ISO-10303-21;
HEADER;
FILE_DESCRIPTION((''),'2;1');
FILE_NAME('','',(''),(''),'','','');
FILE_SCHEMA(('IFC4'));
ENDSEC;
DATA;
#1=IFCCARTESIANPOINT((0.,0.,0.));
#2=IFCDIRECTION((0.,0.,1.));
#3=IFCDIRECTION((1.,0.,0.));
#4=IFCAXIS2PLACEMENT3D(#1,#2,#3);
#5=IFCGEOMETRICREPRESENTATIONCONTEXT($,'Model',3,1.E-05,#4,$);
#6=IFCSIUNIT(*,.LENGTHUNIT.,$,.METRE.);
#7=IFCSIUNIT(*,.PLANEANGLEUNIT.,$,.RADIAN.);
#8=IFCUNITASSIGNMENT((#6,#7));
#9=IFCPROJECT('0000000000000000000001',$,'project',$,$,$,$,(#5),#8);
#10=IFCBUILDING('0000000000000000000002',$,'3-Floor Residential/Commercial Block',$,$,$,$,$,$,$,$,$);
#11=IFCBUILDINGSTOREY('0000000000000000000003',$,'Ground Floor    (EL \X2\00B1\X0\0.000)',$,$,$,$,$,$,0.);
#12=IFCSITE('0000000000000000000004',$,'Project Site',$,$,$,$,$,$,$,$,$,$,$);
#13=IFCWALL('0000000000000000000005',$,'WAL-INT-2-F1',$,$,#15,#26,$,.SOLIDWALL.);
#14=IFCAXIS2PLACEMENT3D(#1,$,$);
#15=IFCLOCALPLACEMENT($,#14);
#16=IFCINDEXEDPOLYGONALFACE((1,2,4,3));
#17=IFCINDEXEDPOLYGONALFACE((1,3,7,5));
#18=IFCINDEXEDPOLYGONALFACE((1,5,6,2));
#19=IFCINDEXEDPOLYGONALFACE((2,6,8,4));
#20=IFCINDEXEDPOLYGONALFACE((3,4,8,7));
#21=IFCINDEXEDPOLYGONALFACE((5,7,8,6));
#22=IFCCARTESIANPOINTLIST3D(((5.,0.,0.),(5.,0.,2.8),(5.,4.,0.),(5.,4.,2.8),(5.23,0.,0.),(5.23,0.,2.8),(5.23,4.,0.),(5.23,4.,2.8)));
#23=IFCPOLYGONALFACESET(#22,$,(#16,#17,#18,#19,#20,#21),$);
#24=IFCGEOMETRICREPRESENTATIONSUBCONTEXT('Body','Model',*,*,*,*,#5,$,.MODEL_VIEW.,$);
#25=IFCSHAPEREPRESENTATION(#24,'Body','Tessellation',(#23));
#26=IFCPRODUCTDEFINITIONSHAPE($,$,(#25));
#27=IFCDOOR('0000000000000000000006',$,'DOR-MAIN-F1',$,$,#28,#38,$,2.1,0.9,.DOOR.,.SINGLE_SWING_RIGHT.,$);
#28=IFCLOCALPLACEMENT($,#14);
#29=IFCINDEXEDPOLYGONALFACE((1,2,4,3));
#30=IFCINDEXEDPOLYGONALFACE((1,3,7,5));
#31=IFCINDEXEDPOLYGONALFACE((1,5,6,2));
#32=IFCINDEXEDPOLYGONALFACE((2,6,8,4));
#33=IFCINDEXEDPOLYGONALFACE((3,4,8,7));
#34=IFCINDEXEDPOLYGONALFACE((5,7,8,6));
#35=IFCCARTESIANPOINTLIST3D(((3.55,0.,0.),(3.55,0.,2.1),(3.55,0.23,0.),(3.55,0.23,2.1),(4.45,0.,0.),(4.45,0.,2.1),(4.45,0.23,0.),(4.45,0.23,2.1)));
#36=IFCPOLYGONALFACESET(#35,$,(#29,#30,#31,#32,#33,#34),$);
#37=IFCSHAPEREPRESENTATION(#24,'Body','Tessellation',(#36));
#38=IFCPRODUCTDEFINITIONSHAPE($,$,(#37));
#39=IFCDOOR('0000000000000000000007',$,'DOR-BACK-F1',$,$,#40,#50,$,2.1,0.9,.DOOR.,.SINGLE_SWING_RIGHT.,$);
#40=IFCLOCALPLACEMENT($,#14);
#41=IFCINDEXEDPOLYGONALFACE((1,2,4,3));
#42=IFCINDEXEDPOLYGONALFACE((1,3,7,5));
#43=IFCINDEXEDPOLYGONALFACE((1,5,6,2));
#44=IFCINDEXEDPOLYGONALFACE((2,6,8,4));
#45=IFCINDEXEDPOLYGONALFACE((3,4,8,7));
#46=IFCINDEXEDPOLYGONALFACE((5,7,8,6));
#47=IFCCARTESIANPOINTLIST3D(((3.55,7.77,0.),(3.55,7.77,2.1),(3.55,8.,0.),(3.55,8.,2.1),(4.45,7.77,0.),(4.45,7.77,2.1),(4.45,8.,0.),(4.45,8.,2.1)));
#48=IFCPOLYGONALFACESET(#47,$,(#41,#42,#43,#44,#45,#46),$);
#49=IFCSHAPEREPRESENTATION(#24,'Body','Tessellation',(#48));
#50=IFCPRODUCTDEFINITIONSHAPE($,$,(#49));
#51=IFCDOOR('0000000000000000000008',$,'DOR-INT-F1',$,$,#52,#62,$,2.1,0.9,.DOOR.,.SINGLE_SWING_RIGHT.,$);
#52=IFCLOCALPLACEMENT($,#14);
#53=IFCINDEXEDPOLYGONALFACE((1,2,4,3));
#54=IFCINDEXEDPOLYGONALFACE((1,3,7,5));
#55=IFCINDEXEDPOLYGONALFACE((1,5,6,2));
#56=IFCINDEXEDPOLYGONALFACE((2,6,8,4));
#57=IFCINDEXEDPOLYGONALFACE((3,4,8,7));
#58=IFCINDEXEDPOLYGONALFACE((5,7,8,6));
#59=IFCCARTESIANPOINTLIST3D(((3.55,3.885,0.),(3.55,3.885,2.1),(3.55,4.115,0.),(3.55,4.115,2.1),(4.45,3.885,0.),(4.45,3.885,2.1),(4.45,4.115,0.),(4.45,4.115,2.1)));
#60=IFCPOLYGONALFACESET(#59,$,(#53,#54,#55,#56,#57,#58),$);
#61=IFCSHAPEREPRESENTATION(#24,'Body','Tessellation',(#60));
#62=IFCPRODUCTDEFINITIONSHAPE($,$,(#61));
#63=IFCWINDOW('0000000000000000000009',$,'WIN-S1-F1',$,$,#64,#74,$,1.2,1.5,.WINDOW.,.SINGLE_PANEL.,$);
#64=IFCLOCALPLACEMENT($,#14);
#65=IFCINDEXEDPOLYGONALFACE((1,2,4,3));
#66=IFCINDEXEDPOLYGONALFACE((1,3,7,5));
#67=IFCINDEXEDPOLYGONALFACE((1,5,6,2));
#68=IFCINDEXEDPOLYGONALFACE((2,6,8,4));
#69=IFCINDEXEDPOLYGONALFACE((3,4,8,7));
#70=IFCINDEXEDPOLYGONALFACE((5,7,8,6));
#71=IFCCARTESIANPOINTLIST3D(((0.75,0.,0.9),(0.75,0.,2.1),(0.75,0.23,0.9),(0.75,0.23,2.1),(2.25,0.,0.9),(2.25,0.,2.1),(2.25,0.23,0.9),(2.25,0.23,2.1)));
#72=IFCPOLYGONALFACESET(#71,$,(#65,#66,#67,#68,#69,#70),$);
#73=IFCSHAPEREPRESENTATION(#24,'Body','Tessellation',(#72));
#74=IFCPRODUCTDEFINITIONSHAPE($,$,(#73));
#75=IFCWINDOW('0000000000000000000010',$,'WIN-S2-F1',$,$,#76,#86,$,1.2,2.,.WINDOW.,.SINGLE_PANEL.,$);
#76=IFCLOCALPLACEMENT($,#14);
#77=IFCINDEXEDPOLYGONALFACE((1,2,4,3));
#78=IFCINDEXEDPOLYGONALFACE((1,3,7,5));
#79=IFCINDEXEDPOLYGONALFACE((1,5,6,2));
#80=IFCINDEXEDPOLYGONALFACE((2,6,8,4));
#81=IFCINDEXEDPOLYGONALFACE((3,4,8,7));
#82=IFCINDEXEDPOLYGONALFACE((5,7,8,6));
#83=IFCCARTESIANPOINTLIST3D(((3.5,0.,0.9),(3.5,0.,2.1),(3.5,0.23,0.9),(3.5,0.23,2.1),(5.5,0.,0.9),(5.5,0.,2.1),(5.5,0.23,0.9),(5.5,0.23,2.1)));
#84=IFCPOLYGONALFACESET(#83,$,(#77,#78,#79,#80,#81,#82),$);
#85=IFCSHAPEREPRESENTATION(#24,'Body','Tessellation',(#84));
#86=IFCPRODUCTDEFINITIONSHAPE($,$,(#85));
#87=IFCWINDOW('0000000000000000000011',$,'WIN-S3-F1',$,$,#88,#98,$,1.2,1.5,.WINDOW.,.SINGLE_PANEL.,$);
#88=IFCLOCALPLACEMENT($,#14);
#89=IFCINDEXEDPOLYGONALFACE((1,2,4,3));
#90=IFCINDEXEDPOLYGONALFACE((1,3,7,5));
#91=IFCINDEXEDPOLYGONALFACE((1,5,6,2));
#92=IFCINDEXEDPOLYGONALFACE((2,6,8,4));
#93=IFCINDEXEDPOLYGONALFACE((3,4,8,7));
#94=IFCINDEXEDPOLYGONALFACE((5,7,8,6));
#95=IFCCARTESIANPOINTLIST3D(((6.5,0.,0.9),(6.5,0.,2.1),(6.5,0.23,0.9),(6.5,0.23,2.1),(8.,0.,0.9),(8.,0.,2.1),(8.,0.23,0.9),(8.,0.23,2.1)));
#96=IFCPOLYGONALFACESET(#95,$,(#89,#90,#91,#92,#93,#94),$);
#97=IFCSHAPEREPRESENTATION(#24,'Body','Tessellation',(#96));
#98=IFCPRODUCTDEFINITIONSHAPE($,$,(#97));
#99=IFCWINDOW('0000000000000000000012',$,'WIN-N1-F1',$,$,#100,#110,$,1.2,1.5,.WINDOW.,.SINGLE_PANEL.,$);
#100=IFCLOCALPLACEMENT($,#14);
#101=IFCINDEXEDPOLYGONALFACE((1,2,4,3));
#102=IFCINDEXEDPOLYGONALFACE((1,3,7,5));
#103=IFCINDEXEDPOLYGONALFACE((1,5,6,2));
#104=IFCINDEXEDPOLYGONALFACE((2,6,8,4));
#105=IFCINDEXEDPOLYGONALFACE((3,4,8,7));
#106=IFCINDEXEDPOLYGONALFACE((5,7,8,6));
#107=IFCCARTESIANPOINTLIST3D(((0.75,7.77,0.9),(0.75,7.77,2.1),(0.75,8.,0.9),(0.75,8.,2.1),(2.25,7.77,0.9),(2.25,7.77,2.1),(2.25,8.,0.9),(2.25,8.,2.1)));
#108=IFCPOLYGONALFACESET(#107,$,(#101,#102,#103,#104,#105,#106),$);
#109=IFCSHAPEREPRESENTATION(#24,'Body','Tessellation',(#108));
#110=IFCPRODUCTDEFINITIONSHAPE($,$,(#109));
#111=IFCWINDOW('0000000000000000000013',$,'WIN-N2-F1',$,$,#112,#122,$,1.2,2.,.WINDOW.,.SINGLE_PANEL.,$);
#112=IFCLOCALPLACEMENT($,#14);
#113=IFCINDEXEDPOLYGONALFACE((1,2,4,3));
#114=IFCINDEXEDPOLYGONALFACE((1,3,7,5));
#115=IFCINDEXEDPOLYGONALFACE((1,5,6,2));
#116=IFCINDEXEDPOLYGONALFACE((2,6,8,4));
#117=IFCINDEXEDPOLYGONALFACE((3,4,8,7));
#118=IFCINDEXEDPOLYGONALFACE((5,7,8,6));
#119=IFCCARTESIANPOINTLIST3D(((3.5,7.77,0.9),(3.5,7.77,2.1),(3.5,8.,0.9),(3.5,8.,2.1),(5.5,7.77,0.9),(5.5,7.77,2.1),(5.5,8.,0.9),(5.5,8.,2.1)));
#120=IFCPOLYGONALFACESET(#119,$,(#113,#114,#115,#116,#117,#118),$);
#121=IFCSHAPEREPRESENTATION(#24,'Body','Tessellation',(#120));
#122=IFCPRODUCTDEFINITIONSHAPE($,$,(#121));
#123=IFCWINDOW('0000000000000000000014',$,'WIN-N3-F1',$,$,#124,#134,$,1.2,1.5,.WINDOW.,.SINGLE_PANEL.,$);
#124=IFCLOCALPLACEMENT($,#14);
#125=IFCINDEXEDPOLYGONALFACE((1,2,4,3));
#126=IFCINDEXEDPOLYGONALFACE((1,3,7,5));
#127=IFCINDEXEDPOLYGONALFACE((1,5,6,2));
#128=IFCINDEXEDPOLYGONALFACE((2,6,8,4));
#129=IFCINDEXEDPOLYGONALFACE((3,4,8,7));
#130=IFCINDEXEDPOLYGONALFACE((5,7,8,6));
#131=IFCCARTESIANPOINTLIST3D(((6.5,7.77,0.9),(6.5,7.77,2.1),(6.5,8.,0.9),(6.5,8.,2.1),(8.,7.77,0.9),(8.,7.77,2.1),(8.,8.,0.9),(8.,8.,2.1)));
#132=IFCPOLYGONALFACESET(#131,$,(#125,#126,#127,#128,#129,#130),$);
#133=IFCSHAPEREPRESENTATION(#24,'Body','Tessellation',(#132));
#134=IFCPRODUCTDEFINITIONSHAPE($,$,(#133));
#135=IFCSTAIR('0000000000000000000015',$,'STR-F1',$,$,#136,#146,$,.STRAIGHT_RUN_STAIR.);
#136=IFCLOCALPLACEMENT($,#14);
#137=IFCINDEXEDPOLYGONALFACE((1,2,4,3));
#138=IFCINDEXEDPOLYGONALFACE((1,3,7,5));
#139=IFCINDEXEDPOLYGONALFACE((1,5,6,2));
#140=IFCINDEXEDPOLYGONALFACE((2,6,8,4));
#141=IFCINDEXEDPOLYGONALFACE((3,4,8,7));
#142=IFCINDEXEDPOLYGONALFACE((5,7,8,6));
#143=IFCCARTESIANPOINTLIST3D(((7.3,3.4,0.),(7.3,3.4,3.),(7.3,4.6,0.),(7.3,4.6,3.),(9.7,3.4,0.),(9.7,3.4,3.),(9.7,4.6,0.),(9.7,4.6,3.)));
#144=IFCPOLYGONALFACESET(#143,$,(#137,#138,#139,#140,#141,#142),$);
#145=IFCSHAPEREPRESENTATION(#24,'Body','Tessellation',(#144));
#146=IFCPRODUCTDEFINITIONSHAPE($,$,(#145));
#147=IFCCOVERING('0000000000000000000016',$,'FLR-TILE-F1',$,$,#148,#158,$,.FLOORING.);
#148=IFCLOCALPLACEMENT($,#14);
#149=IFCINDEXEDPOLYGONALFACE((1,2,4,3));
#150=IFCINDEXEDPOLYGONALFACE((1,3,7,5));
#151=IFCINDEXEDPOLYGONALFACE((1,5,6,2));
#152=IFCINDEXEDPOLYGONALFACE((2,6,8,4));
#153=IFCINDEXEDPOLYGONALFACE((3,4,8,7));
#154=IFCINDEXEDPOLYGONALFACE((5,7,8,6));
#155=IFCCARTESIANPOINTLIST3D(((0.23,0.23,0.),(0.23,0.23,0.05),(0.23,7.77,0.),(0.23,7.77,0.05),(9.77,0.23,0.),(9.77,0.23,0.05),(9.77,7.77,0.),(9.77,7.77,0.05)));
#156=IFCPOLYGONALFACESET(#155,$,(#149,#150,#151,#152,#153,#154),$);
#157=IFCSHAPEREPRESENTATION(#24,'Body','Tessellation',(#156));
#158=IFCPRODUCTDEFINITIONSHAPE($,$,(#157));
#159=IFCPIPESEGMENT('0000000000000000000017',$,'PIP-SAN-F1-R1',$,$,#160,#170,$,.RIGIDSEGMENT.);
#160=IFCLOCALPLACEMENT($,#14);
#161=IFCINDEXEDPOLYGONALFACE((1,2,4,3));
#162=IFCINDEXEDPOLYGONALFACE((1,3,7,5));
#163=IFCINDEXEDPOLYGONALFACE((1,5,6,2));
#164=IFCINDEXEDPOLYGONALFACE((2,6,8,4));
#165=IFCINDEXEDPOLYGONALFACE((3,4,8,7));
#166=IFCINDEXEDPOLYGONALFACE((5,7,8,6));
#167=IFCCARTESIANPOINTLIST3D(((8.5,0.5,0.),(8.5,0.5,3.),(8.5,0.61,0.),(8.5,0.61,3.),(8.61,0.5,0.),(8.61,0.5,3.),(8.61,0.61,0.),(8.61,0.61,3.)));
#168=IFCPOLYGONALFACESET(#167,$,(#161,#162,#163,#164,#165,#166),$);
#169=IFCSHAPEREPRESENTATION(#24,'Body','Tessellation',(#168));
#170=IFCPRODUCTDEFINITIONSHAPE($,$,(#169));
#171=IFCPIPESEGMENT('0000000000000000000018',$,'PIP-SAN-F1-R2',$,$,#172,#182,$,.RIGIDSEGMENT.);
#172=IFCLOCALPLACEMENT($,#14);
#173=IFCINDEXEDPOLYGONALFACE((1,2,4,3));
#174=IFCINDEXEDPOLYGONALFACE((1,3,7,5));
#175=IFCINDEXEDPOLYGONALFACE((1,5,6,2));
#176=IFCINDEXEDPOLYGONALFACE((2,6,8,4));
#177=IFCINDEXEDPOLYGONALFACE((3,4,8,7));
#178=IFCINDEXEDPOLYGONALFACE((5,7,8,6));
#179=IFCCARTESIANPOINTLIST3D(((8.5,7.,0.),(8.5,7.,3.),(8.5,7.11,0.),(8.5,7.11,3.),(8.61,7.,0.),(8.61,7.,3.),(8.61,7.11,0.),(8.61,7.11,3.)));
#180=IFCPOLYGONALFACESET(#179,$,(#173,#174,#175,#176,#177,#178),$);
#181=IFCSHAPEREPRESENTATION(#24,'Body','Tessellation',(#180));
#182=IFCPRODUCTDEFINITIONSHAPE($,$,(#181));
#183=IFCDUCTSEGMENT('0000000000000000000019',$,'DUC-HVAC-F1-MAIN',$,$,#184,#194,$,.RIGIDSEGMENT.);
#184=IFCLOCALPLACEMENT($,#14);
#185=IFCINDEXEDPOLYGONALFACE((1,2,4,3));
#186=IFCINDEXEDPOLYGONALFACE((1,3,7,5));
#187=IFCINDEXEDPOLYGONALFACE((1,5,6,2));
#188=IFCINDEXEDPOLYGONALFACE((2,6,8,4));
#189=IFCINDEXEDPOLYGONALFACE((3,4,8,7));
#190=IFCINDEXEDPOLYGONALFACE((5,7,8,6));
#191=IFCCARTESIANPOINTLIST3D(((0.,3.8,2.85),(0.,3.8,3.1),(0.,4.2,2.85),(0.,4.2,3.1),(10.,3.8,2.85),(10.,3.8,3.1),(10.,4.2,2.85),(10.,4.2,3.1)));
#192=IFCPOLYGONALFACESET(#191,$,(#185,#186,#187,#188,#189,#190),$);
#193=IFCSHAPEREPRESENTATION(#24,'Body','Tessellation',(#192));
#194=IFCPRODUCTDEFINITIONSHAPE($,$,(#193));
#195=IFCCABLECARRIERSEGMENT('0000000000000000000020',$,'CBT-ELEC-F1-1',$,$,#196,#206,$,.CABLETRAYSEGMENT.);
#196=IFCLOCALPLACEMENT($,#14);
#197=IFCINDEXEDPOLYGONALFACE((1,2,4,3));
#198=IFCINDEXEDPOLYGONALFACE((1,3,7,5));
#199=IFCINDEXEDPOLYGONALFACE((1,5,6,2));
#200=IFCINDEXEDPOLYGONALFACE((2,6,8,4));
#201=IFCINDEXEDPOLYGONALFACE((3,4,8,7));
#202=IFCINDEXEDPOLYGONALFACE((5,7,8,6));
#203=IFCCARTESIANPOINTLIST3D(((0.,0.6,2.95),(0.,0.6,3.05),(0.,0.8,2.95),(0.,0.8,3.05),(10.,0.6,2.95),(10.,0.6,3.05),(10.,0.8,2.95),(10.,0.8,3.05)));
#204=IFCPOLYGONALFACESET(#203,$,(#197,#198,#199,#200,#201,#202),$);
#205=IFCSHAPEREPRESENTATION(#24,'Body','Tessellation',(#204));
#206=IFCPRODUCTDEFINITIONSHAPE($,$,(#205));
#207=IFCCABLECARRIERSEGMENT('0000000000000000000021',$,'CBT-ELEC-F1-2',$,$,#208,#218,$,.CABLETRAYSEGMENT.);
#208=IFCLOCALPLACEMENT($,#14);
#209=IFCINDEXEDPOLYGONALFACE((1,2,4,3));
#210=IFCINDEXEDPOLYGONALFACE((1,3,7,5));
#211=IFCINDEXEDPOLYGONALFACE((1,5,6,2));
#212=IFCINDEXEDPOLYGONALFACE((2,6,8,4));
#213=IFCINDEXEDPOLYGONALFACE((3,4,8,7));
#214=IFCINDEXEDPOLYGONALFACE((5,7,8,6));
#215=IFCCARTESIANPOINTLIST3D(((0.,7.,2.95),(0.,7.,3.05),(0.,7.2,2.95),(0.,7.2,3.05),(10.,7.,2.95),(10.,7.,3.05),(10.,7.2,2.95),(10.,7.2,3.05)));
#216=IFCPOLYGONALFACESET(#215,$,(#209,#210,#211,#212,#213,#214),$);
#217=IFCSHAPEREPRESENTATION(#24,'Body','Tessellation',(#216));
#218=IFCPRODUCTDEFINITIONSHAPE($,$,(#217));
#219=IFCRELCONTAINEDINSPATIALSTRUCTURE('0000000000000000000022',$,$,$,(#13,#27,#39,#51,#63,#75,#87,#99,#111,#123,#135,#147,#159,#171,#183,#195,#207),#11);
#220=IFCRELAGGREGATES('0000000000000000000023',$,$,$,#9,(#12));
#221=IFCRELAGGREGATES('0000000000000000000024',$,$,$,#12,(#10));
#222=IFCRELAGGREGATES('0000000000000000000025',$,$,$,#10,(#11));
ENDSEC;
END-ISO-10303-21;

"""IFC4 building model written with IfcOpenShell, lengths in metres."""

from ifc_helpers import new_model, si_unit, frame, frame_2d, origin_with_axes, place, context, subcontext, project, spatial, rectangle, extrude, element, save


model = new_model("IFC4")

# Units and contexts
model_context = context("Model", 3, precision=1e-05, world=origin_with_axes())
body_context = subcontext(model_context, "Body", "Model", "MODEL_VIEW")
ifc_project = project(units=[si_unit("LENGTHUNIT", "METRE"), si_unit("PLANEANGLEUNIT", "RADIAN")], contexts=[model_context])

# Site, building, storey
site = spatial("IfcSite", under=ifc_project, Name="Project Site")
building = spatial("IfcBuilding", under=site, Name="3-Floor Residential/Commercial Block")
storey = spatial("IfcBuildingStorey", under=building, Name="Ground Floor    (EL ±0.000)", Elevation=0.0)

# Wall
wall_1_placement = place(None, frame((5.0, 0.0, 0.0), z_axis=(0.0, 0.0, 1.0), x_axis=(1.0, 0.0, 0.0)))
element("IfcWall", 1, at=wall_1_placement, inside=storey, Name="WAL-INT-2-F1", PredefinedType="SOLIDWALL", context=body_context, shape_type="SweptSolid", body=[
    extrude(rectangle(XDim=0.23, YDim=4.0, at=frame_2d((0.115, 2.0))), origin_with_axes(), (0.0, 0.0, 1.0), 2.8),
])

# Doors
for number, where, z_axis, x_axis, name in (
    (2, (3.55, 0.0, 0.0), (0.0, 0.0, 1.0), (1.0, 0.0, 0.0), "DOR-MAIN-F1"),
    (3, (3.55, 7.77, 0.0), (0.0, 0.0, 1.0), (1.0, 0.0, 0.0), "DOR-BACK-F1"),
    (4, (3.55, 3.885, 0.0), (0.0, 0.0, 1.0), (1.0, 0.0, 0.0), "DOR-INT-F1"),
):
    element("IfcDoor", number, at=place(None, frame(where, z_axis=z_axis, x_axis=x_axis)), inside=storey, Name=name, OperationType="SINGLE_SWING_RIGHT", OverallHeight=2.1, OverallWidth=0.9, PredefinedType="DOOR", context=body_context, shape_type="SweptSolid", body=[
        extrude(rectangle(XDim=0.9, YDim=0.23, at=frame_2d((0.45, 0.115))), origin_with_axes(), (0.0, 0.0, 1.0), 2.1),
    ])

# Windows
window_1_placement = place(None, frame((0.75, 0.0, 0.9), z_axis=(0.0, 0.0, 1.0), x_axis=(1.0, 0.0, 0.0)))
element("IfcWindow", 5, at=window_1_placement, inside=storey, Name="WIN-S1-F1", OverallHeight=1.2, OverallWidth=1.5, PartitioningType="SINGLE_PANEL", PredefinedType="WINDOW", context=body_context, shape_type="SweptSolid", body=[
    extrude(rectangle(XDim=1.5, YDim=0.23, at=frame_2d((0.75, 0.115))), origin_with_axes(), (0.0, 0.0, 1.0), 1.2),
])
window_2_placement = place(None, frame((3.5, 0.0, 0.9), z_axis=(0.0, 0.0, 1.0), x_axis=(1.0, 0.0, 0.0)))
element("IfcWindow", 6, at=window_2_placement, inside=storey, Name="WIN-S2-F1", OverallHeight=1.2, OverallWidth=2.0, PartitioningType="SINGLE_PANEL", PredefinedType="WINDOW", context=body_context, shape_type="SweptSolid", body=[
    extrude(rectangle(XDim=2.0, YDim=0.23, at=frame_2d((1.0, 0.115))), origin_with_axes(), (0.0, 0.0, 1.0), 1.2),
])
for number, where, z_axis, x_axis, name in (
    (7, (6.5, 0.0, 0.9), (0.0, 0.0, 1.0), (1.0, 0.0, 0.0), "WIN-S3-F1"),
    (8, (0.75, 7.77, 0.9), (0.0, 0.0, 1.0), (1.0, 0.0, 0.0), "WIN-N1-F1"),
):
    element("IfcWindow", number, at=place(None, frame(where, z_axis=z_axis, x_axis=x_axis)), inside=storey, Name=name, OverallHeight=1.2, OverallWidth=1.5, PartitioningType="SINGLE_PANEL", PredefinedType="WINDOW", context=body_context, shape_type="SweptSolid", body=[
        extrude(rectangle(XDim=1.5, YDim=0.23, at=frame_2d((0.75, 0.115))), origin_with_axes(), (0.0, 0.0, 1.0), 1.2),
    ])
window_3_placement = place(None, frame((3.5, 7.77, 0.9), z_axis=(0.0, 0.0, 1.0), x_axis=(1.0, 0.0, 0.0)))
element("IfcWindow", 9, at=window_3_placement, inside=storey, Name="WIN-N2-F1", OverallHeight=1.2, OverallWidth=2.0, PartitioningType="SINGLE_PANEL", PredefinedType="WINDOW", context=body_context, shape_type="SweptSolid", body=[
    extrude(rectangle(XDim=2.0, YDim=0.23, at=frame_2d((1.0, 0.115))), origin_with_axes(), (0.0, 0.0, 1.0), 1.2),
])
window_4_placement = place(None, frame((6.5, 7.77, 0.9), z_axis=(0.0, 0.0, 1.0), x_axis=(1.0, 0.0, 0.0)))
element("IfcWindow", 10, at=window_4_placement, inside=storey, Name="WIN-N3-F1", OverallHeight=1.2, OverallWidth=1.5, PartitioningType="SINGLE_PANEL", PredefinedType="WINDOW", context=body_context, shape_type="SweptSolid", body=[
    extrude(rectangle(XDim=1.5, YDim=0.23, at=frame_2d((0.75, 0.115))), origin_with_axes(), (0.0, 0.0, 1.0), 1.2),
])

# Stair
stair_placement = place(None, frame((7.3, 3.4, 0.0), z_axis=(0.0, 0.0, 1.0), x_axis=(1.0, 0.0, 0.0)))
element("IfcStair", 11, at=stair_placement, inside=storey, Name="STR-F1", PredefinedType="STRAIGHT_RUN_STAIR", context=body_context, shape_type="SweptSolid", body=[
    extrude(rectangle(XDim=2.4, YDim=1.2, at=frame_2d((1.2, 0.6))), origin_with_axes(), (0.0, 0.0, 1.0), 3.0),
])

# Covering
covering_placement = place(None, frame((0.23, 0.23, 0.0), z_axis=(0.0, 0.0, 1.0), x_axis=(1.0, 0.0, 0.0)))
element("IfcCovering", 12, at=covering_placement, inside=storey, Name="FLR-TILE-F1", PredefinedType="FLOORING", context=body_context, shape_type="SweptSolid", body=[
    extrude(rectangle(XDim=9.54, YDim=7.54, at=frame_2d((4.77, 3.77))), origin_with_axes(), (0.0, 0.0, 1.0), 0.05),
])

# Pipe segments
for number, where, z_axis, x_axis, name in (
    (13, (8.5, 0.5, 0.0), (0.0, 0.0, 1.0), (1.0, 0.0, 0.0), "PIP-SAN-F1-R1"),
    (14, (8.5, 7.0, 0.0), (0.0, 0.0, 1.0), (1.0, 0.0, 0.0), "PIP-SAN-F1-R2"),
):
    element("IfcPipeSegment", number, at=place(None, frame(where, z_axis=z_axis, x_axis=x_axis)), inside=storey, Name=name, PredefinedType="RIGIDSEGMENT", context=body_context, shape_type="SweptSolid", body=[
        extrude(rectangle(XDim=0.11, YDim=0.11, at=frame_2d((0.055, 0.055))), origin_with_axes(), (0.0, 0.0, 1.0), 3.0),
    ])

# Duct segment
duct_segment_placement = place(None, frame((0.0, 3.8, 2.85), z_axis=(0.0, 0.0, 1.0), x_axis=(1.0, 0.0, 0.0)))
element("IfcDuctSegment", 15, at=duct_segment_placement, inside=storey, Name="DUC-HVAC-F1-MAIN", PredefinedType="RIGIDSEGMENT", context=body_context, shape_type="SweptSolid", body=[
    extrude(rectangle(XDim=10.0, YDim=0.4, at=frame_2d((5.0, 0.2))), origin_with_axes(), (0.0, 0.0, 1.0), 0.25),
])

# Cable carrier segments
for number, where, z_axis, x_axis, name in (
    (16, (0.0, 0.6, 2.95), (0.0, 0.0, 1.0), (1.0, 0.0, 0.0), "CBT-ELEC-F1-1"),
    (17, (0.0, 7.0, 2.95), (0.0, 0.0, 1.0), (1.0, 0.0, 0.0), "CBT-ELEC-F1-2"),
):
    element("IfcCableCarrierSegment", number, at=place(None, frame(where, z_axis=z_axis, x_axis=x_axis)), inside=storey, Name=name, PredefinedType="CABLETRAYSEGMENT", context=body_context, shape_type="SweptSolid", body=[
        extrude(rectangle(XDim=10.0, YDim=0.2, at=frame_2d((5.0, 0.1))), origin_with_axes(), (0.0, 0.0, 1.0), 0.1),
    ])

save(model, "model.ifc")
